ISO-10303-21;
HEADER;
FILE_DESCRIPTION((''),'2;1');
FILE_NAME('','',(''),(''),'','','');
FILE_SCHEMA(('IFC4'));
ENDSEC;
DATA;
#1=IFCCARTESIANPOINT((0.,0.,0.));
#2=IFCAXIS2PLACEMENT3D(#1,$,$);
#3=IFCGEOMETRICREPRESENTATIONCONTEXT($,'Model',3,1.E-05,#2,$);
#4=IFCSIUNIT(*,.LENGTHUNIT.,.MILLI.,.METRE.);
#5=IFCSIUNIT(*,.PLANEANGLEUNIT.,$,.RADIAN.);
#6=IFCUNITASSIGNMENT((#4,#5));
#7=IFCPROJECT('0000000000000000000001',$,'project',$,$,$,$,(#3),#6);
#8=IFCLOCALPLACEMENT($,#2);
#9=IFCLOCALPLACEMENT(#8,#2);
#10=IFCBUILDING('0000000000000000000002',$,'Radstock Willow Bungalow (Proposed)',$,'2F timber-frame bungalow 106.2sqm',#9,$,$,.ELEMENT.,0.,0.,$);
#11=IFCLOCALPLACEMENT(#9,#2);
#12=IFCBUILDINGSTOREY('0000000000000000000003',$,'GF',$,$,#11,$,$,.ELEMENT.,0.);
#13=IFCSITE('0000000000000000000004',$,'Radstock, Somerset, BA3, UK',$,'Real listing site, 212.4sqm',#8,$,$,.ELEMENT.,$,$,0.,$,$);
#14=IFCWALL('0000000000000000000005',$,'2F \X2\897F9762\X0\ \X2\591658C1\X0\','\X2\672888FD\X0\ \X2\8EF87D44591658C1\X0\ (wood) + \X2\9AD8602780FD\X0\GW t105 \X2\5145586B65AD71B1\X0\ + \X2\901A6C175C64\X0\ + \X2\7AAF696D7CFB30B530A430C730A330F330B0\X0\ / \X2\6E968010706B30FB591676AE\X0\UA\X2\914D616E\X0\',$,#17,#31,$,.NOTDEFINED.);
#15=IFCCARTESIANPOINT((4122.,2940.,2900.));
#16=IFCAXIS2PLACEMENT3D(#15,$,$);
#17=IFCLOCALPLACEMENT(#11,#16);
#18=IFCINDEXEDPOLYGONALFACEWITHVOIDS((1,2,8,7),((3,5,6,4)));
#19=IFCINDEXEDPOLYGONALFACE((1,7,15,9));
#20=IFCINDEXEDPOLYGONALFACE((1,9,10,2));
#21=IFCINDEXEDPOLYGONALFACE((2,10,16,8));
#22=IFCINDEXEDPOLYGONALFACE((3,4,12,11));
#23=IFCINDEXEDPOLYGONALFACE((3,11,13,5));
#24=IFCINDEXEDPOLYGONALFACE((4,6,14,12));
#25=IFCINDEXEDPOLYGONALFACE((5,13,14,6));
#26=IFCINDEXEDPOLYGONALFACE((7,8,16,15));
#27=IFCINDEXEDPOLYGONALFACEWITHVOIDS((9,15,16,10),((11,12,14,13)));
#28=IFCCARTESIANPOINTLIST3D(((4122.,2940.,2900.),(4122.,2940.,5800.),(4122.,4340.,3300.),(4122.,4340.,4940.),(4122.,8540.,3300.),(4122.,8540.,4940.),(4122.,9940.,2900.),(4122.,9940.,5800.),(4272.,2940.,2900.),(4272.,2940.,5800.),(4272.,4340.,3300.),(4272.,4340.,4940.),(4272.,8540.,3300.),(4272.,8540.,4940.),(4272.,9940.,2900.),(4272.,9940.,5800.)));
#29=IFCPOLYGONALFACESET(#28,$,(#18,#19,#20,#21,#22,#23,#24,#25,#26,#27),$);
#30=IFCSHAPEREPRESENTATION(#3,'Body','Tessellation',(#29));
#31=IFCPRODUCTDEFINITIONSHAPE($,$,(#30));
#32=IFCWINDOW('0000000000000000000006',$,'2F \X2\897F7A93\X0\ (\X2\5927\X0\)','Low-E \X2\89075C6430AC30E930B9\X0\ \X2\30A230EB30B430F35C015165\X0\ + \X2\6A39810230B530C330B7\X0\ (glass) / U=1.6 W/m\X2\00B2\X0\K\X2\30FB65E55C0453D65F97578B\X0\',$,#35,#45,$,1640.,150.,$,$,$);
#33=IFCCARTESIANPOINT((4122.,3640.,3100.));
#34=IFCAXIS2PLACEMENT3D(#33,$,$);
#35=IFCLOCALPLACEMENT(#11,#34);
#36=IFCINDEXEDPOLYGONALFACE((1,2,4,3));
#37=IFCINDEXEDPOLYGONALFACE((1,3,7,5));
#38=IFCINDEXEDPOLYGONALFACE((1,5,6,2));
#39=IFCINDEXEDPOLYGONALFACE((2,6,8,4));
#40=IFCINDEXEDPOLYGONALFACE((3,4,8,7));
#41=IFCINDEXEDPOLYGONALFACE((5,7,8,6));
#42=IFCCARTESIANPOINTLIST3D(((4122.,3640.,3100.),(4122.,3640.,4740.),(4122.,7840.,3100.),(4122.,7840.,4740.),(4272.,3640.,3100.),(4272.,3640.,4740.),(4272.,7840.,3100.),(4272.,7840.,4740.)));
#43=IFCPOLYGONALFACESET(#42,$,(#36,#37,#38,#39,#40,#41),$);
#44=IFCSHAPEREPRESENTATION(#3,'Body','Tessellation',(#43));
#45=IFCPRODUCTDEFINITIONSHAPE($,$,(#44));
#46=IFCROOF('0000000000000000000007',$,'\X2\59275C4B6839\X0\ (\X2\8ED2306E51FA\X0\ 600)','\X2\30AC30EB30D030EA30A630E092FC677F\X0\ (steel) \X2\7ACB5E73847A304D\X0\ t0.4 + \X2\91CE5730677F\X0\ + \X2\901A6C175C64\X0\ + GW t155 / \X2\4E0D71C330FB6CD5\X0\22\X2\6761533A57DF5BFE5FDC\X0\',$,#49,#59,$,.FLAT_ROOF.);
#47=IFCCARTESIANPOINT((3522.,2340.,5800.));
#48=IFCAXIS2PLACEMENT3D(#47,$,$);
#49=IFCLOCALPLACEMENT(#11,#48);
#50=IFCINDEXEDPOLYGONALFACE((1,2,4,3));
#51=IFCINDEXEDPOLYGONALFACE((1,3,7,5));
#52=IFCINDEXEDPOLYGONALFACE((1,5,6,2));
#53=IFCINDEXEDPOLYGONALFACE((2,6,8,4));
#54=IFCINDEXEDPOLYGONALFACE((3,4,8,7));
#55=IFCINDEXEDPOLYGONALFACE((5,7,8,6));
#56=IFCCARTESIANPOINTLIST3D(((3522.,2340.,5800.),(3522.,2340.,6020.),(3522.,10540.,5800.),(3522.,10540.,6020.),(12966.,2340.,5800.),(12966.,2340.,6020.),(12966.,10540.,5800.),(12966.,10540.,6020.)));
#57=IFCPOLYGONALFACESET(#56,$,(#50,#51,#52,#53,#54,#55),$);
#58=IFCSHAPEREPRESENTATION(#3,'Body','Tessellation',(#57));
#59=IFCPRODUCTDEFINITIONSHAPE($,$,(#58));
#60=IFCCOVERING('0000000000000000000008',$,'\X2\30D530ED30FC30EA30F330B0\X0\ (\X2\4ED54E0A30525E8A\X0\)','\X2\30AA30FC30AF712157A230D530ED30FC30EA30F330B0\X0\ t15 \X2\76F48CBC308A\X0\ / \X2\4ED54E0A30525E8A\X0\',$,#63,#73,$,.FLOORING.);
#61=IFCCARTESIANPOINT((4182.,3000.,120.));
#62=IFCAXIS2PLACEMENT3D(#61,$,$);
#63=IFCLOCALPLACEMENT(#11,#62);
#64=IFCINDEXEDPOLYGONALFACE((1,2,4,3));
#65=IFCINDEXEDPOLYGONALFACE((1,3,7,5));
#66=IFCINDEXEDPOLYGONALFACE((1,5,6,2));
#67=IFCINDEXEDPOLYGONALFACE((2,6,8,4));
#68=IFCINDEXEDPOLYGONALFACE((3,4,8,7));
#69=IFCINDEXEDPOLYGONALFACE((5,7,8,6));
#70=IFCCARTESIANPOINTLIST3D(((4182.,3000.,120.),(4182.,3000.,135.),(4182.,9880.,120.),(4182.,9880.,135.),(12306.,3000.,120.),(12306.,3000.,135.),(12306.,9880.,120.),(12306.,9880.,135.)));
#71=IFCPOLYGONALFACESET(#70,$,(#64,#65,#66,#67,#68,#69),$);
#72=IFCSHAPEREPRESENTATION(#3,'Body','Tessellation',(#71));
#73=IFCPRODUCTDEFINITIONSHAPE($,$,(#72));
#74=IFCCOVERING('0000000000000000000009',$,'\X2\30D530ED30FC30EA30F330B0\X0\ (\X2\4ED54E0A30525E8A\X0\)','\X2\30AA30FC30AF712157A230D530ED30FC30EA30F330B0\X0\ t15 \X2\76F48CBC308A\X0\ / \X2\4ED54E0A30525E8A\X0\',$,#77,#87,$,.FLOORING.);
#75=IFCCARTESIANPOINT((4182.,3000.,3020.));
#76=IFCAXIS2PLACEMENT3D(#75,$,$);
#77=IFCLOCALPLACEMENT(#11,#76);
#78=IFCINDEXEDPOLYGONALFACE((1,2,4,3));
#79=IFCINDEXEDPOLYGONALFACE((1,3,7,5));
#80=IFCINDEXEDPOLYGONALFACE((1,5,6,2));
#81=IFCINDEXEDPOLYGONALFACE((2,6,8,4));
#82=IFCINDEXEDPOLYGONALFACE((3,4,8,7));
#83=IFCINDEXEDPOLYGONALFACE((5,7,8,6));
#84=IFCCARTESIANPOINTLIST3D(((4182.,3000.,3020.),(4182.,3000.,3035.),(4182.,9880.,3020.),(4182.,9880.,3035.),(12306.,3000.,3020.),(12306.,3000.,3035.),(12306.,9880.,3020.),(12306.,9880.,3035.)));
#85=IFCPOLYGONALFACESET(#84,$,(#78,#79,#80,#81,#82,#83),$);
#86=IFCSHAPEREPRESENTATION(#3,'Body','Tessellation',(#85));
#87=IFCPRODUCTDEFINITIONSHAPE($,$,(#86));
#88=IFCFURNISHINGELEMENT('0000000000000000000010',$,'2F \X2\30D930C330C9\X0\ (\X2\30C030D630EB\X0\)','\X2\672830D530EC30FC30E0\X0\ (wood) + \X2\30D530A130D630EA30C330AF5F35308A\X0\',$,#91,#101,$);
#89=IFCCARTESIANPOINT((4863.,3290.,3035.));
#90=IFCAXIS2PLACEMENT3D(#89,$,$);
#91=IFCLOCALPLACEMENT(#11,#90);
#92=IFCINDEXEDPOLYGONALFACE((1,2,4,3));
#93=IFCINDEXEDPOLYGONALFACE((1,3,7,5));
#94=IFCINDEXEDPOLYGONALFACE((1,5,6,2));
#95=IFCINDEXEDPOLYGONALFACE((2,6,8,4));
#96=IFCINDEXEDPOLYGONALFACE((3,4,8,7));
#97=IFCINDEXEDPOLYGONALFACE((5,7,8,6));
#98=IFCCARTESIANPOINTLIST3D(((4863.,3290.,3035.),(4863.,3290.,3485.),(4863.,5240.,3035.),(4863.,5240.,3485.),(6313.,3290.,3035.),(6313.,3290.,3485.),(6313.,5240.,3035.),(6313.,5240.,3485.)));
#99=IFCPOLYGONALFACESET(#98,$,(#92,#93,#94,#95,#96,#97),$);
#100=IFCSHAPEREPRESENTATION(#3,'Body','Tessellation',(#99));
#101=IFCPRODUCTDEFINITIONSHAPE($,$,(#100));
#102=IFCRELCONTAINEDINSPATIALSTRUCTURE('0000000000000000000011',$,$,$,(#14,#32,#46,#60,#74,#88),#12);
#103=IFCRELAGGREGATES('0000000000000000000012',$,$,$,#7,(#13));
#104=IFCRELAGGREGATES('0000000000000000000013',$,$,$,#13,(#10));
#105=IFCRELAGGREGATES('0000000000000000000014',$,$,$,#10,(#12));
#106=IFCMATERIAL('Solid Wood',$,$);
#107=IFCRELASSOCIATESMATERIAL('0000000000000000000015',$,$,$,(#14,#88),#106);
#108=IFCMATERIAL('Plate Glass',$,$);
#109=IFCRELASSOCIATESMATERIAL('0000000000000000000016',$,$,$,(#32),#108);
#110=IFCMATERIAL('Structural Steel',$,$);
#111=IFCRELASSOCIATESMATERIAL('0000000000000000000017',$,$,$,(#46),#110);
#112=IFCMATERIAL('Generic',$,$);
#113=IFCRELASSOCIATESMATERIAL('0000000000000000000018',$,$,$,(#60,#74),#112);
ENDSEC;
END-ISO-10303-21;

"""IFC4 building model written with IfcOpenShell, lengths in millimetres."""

from ifc_helpers import new_model, si_unit, frame, frame_2d, origin, place, context, project, spatial, rectangle, extrude, material, element, fill, save


model = new_model("IFC4")

# Units and contexts
model_context = context("Model", 3, precision=1e-05, world=origin())
ifc_project = project(units=[si_unit("LENGTHUNIT", "METRE", prefix="MILLI"), si_unit("PLANEANGLEUNIT", "RADIAN")], contexts=[model_context])

# Site, building, storey
site_placement = place(None, origin())
site = spatial("IfcSite", under=ifc_project, at=site_placement, Name="Radstock, Somerset, BA3, UK", ObjectType="Real listing site, 212.4sqm", CompositionType="ELEMENT", RefElevation=0.0)
building_placement = place(site_placement, origin())
building = spatial("IfcBuilding", under=site, at=building_placement, Name="Radstock Willow Bungalow (Proposed)", ObjectType="2F timber-frame bungalow 106.2sqm", CompositionType="ELEMENT", ElevationOfRefHeight=0.0, ElevationOfTerrain=0.0)
storey_placement = place(building_placement, origin())
storey = spatial("IfcBuildingStorey", under=building, at=storey_placement, Name="GF", CompositionType="ELEMENT", Elevation=0.0)

# Shared definitions
ifc_material_1 = material(Name="Solid Wood")

# Shared definitions
ifc_material_2 = material(Name="Plate Glass")

# Wall, opening, window
wall_1_placement = place(storey_placement, frame((4122.0, 2940.0, 2900.0)))
wall_1 = element("IfcWall", 1, at=wall_1_placement, inside=storey, material=ifc_material_1, Name="2F 西面 外壁", Description="木製 軸組外壁 (wood) + 高性能GW t105 充填断熱 + 通気層 + 窯業系サイディング / 準耐火・外皮UA配慮", PredefinedType="NOTDEFINED", context=model_context, shape_type="SweptSolid", body=[
    extrude(rectangle(XDim=150.0, YDim=7000.0, at=frame_2d((75.0, 3500.0))), frame((4122.0, 2940.0, 2900.0)), (0.0, 0.0, 1.0), 2900.0),
])
opening_1_placement = place(storey_placement, frame((4122.0, 3640.0, 3100.0)))
opening_1 = element("IfcOpeningElement", 2, at=opening_1_placement, cuts=wall_1, PredefinedType="NOTDEFINED", context=model_context, shape_type="SweptSolid", body=[
    extrude(rectangle(XDim=150.0, YDim=4200.0, at=frame_2d((75.0, 2100.0))), frame((4122.0, 3640.0, 3100.0)), (0.0, 0.0, 1.0), 1640.0),
])
window_1_placement = place(storey_placement, frame((4122.0, 3640.0, 3100.0)))
window_1 = element("IfcWindow", 3, at=window_1_placement, inside=storey, material=ifc_material_2, Name="2F 西窓 (大)", Description="Low-E 複層ガラス アルゴン封入 + 樹脂サッシ (glass) / U=1.6 W/m²K・日射取得型", OverallHeight=1640.0, OverallWidth=150.0, context=model_context, shape_type="SweptSolid", body=[
    extrude(rectangle(XDim=150.0, YDim=4200.0, at=frame_2d((75.0, 2100.0))), frame((4122.0, 3640.0, 3100.0)), (0.0, 0.0, 1.0), 1640.0),
])
fill(opening_1, window_1)

# Roof
ifc_material_3 = material(Name="Structural Steel")
roof_placement = place(storey_placement, frame((3522.0, 2340.0, 5800.0)))
element("IfcRoof", 4, at=roof_placement, inside=storey, material=ifc_material_3, Name="大屋根 (軒の出 600)", Description="ガルバリウム鋼板 (steel) 立平葺き t0.4 + 野地板 + 通気層 + GW t155 / 不燃・法22条区域対応", PredefinedType="FLAT_ROOF", context=model_context, shape_type="SweptSolid", body=[
    extrude(rectangle(XDim=9444.0, YDim=8200.0, at=frame_2d((4722.0, 4100.0))), frame((3522.0, 2340.0, 5800.0)), (0.0, 0.0, 1.0), 220.0),
])

# Coverings
ifc_material_4 = material(Name="Generic")
covering_1_placement = place(storey_placement, frame((4182.0, 3000.0, 120.0)))
element("IfcCovering", 5, at=covering_1_placement, inside=storey, material=ifc_material_4, Name="フローリング (仕上げ床)", Description="オーク無垢フローリング t15 直貼り / 仕上げ床", PredefinedType="FLOORING", context=model_context, shape_type="SweptSolid", body=[
    extrude(rectangle(XDim=8124.0, YDim=6880.0, at=frame_2d((4062.0, 3440.0))), frame((4182.0, 3000.0, 120.0)), (0.0, 0.0, 1.0), 15.0),
])
covering_2_placement = place(storey_placement, frame((4182.0, 3000.0, 3020.0)))
element("IfcCovering", 6, at=covering_2_placement, inside=storey, material=ifc_material_4, Name="フローリング (仕上げ床)", Description="オーク無垢フローリング t15 直貼り / 仕上げ床", PredefinedType="FLOORING", context=model_context, shape_type="SweptSolid", body=[
    extrude(rectangle(XDim=8124.0, YDim=6880.0, at=frame_2d((4062.0, 3440.0))), frame((4182.0, 3000.0, 3020.0)), (0.0, 0.0, 1.0), 15.0),
])

# Furnishing element
furnishing_placement = place(storey_placement, frame((4863.0, 3290.0, 3035.0)))
element("IfcFurnishingElement", 7, at=furnishing_placement, inside=storey, material=ifc_material_1, Name="2F ベッド (ダブル)", Description="木フレーム (wood) + ファブリック張り", context=model_context, shape_type="SweptSolid", body=[
    extrude(rectangle(XDim=1450.0, YDim=1950.0, at=frame_2d((725.0, 975.0))), frame((4863.0, 3290.0, 3035.0)), (0.0, 0.0, 1.0), 450.0),
])

save(model, "model.ifc")
